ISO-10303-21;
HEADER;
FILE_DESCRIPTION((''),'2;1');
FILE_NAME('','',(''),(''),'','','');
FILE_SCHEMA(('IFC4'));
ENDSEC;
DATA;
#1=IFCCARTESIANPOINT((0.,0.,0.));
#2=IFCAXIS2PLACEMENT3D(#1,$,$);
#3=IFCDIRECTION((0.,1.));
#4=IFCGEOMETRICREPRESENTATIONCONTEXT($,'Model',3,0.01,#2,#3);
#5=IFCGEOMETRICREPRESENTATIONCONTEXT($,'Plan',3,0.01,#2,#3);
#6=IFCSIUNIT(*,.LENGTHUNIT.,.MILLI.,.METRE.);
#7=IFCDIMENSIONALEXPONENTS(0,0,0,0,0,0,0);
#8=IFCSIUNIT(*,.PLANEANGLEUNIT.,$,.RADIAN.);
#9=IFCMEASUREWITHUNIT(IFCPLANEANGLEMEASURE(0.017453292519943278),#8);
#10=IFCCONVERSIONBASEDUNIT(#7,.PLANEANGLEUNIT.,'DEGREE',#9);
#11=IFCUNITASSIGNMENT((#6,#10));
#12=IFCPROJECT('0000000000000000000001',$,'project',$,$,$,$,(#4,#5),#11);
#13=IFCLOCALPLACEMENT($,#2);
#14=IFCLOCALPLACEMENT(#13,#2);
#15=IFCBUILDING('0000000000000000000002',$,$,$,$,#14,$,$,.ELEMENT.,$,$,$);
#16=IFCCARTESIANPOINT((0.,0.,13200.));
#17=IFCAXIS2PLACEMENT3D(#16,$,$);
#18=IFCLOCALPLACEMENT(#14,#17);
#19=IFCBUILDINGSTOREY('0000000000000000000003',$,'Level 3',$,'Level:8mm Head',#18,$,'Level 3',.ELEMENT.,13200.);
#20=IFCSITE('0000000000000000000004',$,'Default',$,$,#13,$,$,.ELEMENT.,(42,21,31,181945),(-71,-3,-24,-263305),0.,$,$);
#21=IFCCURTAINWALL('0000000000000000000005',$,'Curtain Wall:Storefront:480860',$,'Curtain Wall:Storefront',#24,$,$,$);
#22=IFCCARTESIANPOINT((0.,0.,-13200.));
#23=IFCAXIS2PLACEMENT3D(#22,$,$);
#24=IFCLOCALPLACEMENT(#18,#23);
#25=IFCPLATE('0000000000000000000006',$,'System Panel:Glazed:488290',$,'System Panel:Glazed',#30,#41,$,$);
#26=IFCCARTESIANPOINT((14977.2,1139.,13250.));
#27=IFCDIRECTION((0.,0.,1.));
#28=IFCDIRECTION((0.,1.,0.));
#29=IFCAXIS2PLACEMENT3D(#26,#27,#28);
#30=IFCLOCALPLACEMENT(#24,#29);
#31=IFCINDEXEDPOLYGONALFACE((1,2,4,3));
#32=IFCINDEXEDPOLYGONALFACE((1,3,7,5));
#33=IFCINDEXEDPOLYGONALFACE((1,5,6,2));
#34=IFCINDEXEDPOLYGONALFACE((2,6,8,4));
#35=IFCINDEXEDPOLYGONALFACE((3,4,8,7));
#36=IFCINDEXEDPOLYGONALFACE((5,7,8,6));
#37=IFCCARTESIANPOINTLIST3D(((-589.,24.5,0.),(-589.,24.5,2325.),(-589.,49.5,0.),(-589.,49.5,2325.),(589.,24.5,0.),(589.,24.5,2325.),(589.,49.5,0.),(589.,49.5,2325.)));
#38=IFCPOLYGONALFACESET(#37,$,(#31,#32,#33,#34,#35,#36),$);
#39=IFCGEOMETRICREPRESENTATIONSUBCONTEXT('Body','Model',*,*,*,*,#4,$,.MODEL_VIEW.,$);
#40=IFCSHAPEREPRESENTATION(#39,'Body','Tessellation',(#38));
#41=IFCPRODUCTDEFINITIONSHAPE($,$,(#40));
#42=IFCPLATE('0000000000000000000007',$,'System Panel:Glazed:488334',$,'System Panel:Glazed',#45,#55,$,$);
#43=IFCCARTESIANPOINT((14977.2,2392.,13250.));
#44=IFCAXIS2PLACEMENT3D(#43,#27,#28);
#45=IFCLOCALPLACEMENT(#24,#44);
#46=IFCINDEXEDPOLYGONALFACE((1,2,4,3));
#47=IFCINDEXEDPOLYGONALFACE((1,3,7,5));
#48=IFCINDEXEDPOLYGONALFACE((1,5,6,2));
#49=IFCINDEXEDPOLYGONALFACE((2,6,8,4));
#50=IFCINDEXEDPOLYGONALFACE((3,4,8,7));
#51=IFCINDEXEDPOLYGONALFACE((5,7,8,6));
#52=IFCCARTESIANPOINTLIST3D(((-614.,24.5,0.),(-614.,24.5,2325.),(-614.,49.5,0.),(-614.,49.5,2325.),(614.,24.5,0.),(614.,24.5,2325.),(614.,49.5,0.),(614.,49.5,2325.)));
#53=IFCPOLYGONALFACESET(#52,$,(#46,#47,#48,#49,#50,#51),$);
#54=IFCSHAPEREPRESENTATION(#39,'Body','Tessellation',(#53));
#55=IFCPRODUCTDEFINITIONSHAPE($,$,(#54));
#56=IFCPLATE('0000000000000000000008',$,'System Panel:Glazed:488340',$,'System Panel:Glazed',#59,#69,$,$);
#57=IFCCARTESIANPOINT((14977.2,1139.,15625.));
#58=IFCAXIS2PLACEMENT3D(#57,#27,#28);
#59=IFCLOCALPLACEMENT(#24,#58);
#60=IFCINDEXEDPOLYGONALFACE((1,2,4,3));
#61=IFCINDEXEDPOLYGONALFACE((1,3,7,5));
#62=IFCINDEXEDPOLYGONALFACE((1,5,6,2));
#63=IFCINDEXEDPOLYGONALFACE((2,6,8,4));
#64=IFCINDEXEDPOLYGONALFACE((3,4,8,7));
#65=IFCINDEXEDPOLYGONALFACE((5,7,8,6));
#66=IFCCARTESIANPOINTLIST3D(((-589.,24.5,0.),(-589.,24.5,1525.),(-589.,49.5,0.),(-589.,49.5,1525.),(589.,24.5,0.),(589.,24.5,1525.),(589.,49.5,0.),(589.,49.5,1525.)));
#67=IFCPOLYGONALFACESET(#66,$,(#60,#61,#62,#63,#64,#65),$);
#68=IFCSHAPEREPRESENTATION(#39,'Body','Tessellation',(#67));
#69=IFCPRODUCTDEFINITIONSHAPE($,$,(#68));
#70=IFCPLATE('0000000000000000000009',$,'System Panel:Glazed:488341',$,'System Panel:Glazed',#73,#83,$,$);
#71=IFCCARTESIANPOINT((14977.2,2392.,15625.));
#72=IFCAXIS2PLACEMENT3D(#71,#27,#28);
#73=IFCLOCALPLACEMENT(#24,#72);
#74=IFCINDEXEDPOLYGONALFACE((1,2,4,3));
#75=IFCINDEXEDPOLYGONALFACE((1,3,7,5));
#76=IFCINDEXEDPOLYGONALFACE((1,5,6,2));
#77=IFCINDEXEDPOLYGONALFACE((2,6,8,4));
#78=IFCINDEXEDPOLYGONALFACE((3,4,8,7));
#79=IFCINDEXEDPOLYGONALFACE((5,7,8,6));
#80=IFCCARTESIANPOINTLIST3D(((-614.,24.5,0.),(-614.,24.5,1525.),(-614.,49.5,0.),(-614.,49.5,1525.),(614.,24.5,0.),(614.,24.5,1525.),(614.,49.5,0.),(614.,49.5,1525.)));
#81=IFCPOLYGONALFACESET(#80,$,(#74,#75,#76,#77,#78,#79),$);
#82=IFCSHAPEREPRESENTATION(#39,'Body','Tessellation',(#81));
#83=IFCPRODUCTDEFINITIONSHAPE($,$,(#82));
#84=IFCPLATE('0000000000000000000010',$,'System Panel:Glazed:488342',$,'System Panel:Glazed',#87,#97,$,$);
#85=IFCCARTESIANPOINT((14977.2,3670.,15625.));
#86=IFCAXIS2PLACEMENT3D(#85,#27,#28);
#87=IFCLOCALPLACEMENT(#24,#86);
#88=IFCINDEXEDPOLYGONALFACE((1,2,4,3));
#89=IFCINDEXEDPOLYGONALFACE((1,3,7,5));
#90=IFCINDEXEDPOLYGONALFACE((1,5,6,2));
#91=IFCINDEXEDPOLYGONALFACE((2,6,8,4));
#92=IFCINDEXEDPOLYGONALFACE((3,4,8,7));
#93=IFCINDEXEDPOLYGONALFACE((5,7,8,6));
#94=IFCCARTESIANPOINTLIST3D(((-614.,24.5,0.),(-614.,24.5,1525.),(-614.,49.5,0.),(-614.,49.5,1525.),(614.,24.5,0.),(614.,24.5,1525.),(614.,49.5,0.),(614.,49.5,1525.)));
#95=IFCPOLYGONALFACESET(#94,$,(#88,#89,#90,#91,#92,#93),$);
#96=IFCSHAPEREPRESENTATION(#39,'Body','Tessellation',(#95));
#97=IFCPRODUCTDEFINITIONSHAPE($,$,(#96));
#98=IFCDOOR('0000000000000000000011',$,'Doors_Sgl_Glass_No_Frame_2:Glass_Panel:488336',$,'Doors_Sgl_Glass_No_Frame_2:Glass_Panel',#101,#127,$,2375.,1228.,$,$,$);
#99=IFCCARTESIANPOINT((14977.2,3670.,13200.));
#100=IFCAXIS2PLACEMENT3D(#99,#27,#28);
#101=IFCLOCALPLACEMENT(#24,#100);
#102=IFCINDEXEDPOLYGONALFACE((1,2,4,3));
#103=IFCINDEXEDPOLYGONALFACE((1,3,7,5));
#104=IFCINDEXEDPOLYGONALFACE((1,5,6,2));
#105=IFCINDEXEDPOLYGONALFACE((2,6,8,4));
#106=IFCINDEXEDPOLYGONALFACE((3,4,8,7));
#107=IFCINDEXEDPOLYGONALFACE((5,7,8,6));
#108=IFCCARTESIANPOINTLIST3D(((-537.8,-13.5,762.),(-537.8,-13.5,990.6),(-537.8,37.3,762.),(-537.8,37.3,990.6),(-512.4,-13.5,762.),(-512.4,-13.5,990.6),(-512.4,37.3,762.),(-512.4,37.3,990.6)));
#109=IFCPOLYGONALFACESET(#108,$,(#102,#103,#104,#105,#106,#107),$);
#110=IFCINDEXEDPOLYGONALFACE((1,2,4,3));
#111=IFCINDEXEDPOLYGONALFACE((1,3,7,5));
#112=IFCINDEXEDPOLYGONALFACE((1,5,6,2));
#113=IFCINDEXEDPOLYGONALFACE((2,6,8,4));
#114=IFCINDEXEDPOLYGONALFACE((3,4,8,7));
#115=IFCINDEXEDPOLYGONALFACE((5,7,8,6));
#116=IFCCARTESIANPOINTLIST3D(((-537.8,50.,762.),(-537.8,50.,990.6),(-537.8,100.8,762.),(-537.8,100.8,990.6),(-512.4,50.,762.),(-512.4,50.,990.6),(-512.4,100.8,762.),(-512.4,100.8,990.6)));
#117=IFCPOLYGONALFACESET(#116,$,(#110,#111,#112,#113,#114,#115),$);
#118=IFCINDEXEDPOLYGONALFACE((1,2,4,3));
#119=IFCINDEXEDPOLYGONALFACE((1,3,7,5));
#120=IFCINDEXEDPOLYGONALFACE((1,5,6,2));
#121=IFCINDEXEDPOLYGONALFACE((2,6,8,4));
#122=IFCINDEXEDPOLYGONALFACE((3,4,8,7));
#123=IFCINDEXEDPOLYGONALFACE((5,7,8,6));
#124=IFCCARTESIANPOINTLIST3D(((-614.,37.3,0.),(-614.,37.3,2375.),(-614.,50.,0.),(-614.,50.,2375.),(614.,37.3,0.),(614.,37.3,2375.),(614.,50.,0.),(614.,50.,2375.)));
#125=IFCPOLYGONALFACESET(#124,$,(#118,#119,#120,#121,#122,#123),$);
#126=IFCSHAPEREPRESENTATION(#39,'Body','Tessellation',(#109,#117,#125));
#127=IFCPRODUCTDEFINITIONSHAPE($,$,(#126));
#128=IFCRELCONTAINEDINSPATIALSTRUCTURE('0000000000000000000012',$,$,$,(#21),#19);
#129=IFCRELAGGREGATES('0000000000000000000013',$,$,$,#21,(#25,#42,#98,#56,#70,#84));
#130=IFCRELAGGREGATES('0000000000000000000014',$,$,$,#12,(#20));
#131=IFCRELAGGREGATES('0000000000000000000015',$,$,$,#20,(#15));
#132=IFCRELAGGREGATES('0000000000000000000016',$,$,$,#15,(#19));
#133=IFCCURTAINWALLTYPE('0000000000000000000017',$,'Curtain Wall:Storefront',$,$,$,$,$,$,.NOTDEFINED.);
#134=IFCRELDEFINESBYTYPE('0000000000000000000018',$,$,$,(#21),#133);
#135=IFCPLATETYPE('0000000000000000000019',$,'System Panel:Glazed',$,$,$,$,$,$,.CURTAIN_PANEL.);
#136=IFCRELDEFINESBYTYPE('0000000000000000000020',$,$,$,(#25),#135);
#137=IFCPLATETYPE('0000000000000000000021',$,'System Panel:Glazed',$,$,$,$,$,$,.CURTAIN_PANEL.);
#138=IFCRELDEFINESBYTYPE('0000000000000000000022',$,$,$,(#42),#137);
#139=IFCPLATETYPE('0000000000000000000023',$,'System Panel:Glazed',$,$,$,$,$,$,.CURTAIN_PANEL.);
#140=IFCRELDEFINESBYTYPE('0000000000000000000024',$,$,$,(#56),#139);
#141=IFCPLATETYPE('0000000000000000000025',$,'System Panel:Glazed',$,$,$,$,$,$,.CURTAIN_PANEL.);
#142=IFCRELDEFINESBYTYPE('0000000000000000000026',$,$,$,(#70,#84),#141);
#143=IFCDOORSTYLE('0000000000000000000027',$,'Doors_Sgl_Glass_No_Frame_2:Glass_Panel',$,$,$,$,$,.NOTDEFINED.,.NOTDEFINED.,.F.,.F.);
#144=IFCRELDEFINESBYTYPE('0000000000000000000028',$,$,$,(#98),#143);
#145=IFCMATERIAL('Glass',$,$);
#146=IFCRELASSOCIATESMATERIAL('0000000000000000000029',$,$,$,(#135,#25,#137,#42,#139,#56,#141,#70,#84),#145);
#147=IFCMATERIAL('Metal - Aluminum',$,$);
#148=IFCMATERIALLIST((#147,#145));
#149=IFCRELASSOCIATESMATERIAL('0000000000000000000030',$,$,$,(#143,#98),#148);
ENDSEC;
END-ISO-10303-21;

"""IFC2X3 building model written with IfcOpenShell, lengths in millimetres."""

from ifc_helpers import new_model, entity, si_unit, converted_unit, direction, frame, frame_2d, origin, origin_2d_with_axis, place, context, subcontext, project, spatial, rectangle, extrude, source, transform, mapped, material, material_list, type_object, type_shapes, element, aggregate, save


model = new_model("IFC2X3")

# Units and contexts
model_context = context("Model", 3, precision=0.01, world=origin(), true_north=direction((0.0, 1.0)))
plan_context = context("Plan", 3, precision=0.01, world=origin(), true_north=direction((0.0, 1.0)))
body_context = subcontext(model_context, "Body", "Model", "MODEL_VIEW")
ifc_project = project(units=[si_unit("LENGTHUNIT", "METRE", prefix="MILLI"), converted_unit("PLANEANGLEUNIT", "DEGREE", entity("IfcPlaneAngleMeasure", 0.017453292519943278), si_unit("PLANEANGLEUNIT", "RADIAN"), dimensions=[0, 0, 0, 0, 0, 0, 0])], contexts=[model_context, plan_context])

# Site, building, storey
site_placement = place(None, origin())
site = spatial("IfcSite", under=ifc_project, at=site_placement, Name="Default", CompositionType="ELEMENT", RefLatitude=(42, 21, 31, 181945), RefLongitude=(-71, -3, -24, -263305), RefElevation=0.0)
building_placement = place(site_placement, origin())
building = spatial("IfcBuilding", under=site, at=building_placement, CompositionType="ELEMENT")
storey_placement = place(building_placement, frame((0.0, 0.0, 13200.0)))
storey = spatial("IfcBuildingStorey", under=building, at=storey_placement, Name="Level 3", ObjectType="Level:8mm Head", LongName="Level 3", CompositionType="ELEMENT", Elevation=13200.0)

# Curtain wall, plates
curtain_wall_type = type_object("IfcCurtainWallType", Name="Curtain Wall:Storefront", PredefinedType="NOTDEFINED")
curtain_wall_placement = place(storey_placement, frame((0.0, 0.0, -13200.0)))
curtain_wall = element("IfcCurtainWall", 1, at=curtain_wall_placement, inside=storey, type_object=curtain_wall_type, Name="Curtain Wall:Storefront:480860", ObjectType="Curtain Wall:Storefront")
ifc_material_1 = material(Name="Glass")
plate_type_1 = type_object("IfcPlateType", Name="System Panel:Glazed", PredefinedType="CURTAIN_PANEL", material=ifc_material_1)
shared_shape_1 = source(origin(), body_context, "Body", "SweptSolid", [
    extrude(rectangle(XDim=25.0, YDim=1178.0, at=origin_2d_with_axis()), frame((0.0, 37.0, 0.0), z_axis=(0.0, 0.0, 1.0), x_axis=(0.0, 1.0, 0.0)), (0.0, 0.0, 1.0), 2325.0),
])
type_shapes(plate_type_1, [shared_shape_1])
plate_1_placement = place(curtain_wall_placement, frame((14977.2, 1139.0, 13250.0), z_axis=(0.0, 0.0, 1.0), x_axis=(0.0, 1.0, 0.0)))
plate_1 = element("IfcPlate", 2, at=plate_1_placement, type_object=plate_type_1, material=ifc_material_1, Name="System Panel:Glazed:488290", ObjectType="System Panel:Glazed", context=body_context, shape_type="MappedRepresentation", body=[
    mapped(shared_shape_1, transform((0.0, 0.0, 0.0), scale=1.0)),
])
plate_type_2 = type_object("IfcPlateType", Name="System Panel:Glazed", PredefinedType="CURTAIN_PANEL", material=ifc_material_1)
shared_shape_2 = source(origin(), body_context, "Body", "SweptSolid", [
    extrude(rectangle(XDim=25.0, YDim=1228.0, at=origin_2d_with_axis()), frame((0.0, 37.0, 0.0), z_axis=(0.0, 0.0, 1.0), x_axis=(0.0, 1.0, 0.0)), (0.0, 0.0, 1.0), 2325.0),
])
type_shapes(plate_type_2, [shared_shape_2])
plate_2_placement = place(curtain_wall_placement, frame((14977.2, 2392.0, 13250.0), z_axis=(0.0, 0.0, 1.0), x_axis=(0.0, 1.0, 0.0)))
plate_2 = element("IfcPlate", 3, at=plate_2_placement, type_object=plate_type_2, material=ifc_material_1, Name="System Panel:Glazed:488334", ObjectType="System Panel:Glazed", context=body_context, shape_type="MappedRepresentation", body=[
    mapped(shared_shape_2, transform((0.0, 0.0, 0.0), scale=1.0)),
])
plate_type_3 = type_object("IfcPlateType", Name="System Panel:Glazed", PredefinedType="CURTAIN_PANEL", material=ifc_material_1)
shared_shape_3 = source(origin(), body_context, "Body", "SweptSolid", [
    extrude(rectangle(XDim=25.0, YDim=1178.0, at=origin_2d_with_axis()), frame((0.0, 37.0, 0.0), z_axis=(0.0, 0.0, 1.0), x_axis=(0.0, 1.0, 0.0)), (0.0, 0.0, 1.0), 1525.0),
])
type_shapes(plate_type_3, [shared_shape_3])
plate_3_placement = place(curtain_wall_placement, frame((14977.2, 1139.0, 15625.0), z_axis=(0.0, 0.0, 1.0), x_axis=(0.0, 1.0, 0.0)))
plate_3 = element("IfcPlate", 4, at=plate_3_placement, type_object=plate_type_3, material=ifc_material_1, Name="System Panel:Glazed:488340", ObjectType="System Panel:Glazed", context=body_context, shape_type="MappedRepresentation", body=[
    mapped(shared_shape_3, transform((0.0, 0.0, 0.0), scale=1.0)),
])
plate_type_4 = type_object("IfcPlateType", Name="System Panel:Glazed", PredefinedType="CURTAIN_PANEL", material=ifc_material_1)
shared_shape_4 = source(origin(), body_context, "Body", "SweptSolid", [
    extrude(rectangle(XDim=25.0, YDim=1228.0, at=origin_2d_with_axis()), frame((0.0, 37.0, 0.0), z_axis=(0.0, 0.0, 1.0), x_axis=(0.0, 1.0, 0.0)), (0.0, 0.0, 1.0), 1525.0),
])
type_shapes(plate_type_4, [shared_shape_4])
plate_4_placement = place(curtain_wall_placement, frame((14977.2, 2392.0, 15625.0), z_axis=(0.0, 0.0, 1.0), x_axis=(0.0, 1.0, 0.0)))
plate_4 = element("IfcPlate", 5, at=plate_4_placement, type_object=plate_type_4, material=ifc_material_1, Name="System Panel:Glazed:488341", ObjectType="System Panel:Glazed", context=body_context, shape_type="MappedRepresentation", body=[
    mapped(shared_shape_4, transform((0.0, 0.0, 0.0), scale=1.0)),
])
plate_5_placement = place(curtain_wall_placement, frame((14977.2, 3670.0, 15625.0), z_axis=(0.0, 0.0, 1.0), x_axis=(0.0, 1.0, 0.0)))
plate_5 = element("IfcPlate", 6, at=plate_5_placement, type_object=plate_type_4, material=ifc_material_1, Name="System Panel:Glazed:488342", ObjectType="System Panel:Glazed", context=body_context, shape_type="MappedRepresentation", body=[
    mapped(shared_shape_4, transform((0.0, 0.0, 0.0), scale=1.0)),
])

# Door
ifc_material_2 = material(Name="Metal - Aluminum")
ifc_material_list = material_list([ifc_material_2, ifc_material_1])
door_style = type_object("IfcDoorStyle", Name="Doors_Sgl_Glass_No_Frame_2:Glass_Panel", ConstructionType="NOTDEFINED", OperationType="NOTDEFINED", ParameterTakesPrecedence=False, Sizeable=False, material=ifc_material_list)
shared_shape_5 = source(origin(), body_context, "Body", "SweptSolid", [
    extrude(rectangle(XDim=50.8, YDim=25.4, at=origin_2d_with_axis()), frame((-525.1, 11.9, 762.0), z_axis=(0.0, 0.0, 1.0), x_axis=(0.0, 1.0, 0.0)), (0.0, 0.0, 1.0), 228.6),
    extrude(rectangle(XDim=50.8, YDim=25.4, at=frame_2d((0.0, 0.0), x_axis=(1.0, 0.0))), frame((-525.1, 75.4, 762.0), z_axis=(0.0, 0.0, 1.0), x_axis=(0.0, -1.0, 0.0)), (0.0, 0.0, 1.0), 228.6),
    extrude(rectangle(XDim=1228.0, YDim=12.7, at=frame_2d((0.0, 0.0), x_axis=(1.0, 0.0))), frame((0.0, 43.7, 0.0), z_axis=(0.0, 0.0, 1.0), x_axis=(-1.0, 0.0, 0.0)), (0.0, 0.0, 1.0), 2375.0),
])
type_shapes(door_style, [shared_shape_5])
door_placement = place(curtain_wall_placement, frame((14977.2, 3670.0, 13200.0), z_axis=(0.0, 0.0, 1.0), x_axis=(0.0, 1.0, 0.0)))
door = element("IfcDoor", 7, at=door_placement, type_object=door_style, material=ifc_material_list, Name="Doors_Sgl_Glass_No_Frame_2:Glass_Panel:488336", ObjectType="Doors_Sgl_Glass_No_Frame_2:Glass_Panel", OverallHeight=2375.0, OverallWidth=1228.0, context=body_context, shape_type="MappedRepresentation", body=[
    mapped(shared_shape_5, transform((0.0, 0.0, 0.0), scale=1.0)),
])
aggregate(curtain_wall, [plate_1, plate_2, door, plate_3, plate_4, plate_5])

save(model, "model.ifc")
